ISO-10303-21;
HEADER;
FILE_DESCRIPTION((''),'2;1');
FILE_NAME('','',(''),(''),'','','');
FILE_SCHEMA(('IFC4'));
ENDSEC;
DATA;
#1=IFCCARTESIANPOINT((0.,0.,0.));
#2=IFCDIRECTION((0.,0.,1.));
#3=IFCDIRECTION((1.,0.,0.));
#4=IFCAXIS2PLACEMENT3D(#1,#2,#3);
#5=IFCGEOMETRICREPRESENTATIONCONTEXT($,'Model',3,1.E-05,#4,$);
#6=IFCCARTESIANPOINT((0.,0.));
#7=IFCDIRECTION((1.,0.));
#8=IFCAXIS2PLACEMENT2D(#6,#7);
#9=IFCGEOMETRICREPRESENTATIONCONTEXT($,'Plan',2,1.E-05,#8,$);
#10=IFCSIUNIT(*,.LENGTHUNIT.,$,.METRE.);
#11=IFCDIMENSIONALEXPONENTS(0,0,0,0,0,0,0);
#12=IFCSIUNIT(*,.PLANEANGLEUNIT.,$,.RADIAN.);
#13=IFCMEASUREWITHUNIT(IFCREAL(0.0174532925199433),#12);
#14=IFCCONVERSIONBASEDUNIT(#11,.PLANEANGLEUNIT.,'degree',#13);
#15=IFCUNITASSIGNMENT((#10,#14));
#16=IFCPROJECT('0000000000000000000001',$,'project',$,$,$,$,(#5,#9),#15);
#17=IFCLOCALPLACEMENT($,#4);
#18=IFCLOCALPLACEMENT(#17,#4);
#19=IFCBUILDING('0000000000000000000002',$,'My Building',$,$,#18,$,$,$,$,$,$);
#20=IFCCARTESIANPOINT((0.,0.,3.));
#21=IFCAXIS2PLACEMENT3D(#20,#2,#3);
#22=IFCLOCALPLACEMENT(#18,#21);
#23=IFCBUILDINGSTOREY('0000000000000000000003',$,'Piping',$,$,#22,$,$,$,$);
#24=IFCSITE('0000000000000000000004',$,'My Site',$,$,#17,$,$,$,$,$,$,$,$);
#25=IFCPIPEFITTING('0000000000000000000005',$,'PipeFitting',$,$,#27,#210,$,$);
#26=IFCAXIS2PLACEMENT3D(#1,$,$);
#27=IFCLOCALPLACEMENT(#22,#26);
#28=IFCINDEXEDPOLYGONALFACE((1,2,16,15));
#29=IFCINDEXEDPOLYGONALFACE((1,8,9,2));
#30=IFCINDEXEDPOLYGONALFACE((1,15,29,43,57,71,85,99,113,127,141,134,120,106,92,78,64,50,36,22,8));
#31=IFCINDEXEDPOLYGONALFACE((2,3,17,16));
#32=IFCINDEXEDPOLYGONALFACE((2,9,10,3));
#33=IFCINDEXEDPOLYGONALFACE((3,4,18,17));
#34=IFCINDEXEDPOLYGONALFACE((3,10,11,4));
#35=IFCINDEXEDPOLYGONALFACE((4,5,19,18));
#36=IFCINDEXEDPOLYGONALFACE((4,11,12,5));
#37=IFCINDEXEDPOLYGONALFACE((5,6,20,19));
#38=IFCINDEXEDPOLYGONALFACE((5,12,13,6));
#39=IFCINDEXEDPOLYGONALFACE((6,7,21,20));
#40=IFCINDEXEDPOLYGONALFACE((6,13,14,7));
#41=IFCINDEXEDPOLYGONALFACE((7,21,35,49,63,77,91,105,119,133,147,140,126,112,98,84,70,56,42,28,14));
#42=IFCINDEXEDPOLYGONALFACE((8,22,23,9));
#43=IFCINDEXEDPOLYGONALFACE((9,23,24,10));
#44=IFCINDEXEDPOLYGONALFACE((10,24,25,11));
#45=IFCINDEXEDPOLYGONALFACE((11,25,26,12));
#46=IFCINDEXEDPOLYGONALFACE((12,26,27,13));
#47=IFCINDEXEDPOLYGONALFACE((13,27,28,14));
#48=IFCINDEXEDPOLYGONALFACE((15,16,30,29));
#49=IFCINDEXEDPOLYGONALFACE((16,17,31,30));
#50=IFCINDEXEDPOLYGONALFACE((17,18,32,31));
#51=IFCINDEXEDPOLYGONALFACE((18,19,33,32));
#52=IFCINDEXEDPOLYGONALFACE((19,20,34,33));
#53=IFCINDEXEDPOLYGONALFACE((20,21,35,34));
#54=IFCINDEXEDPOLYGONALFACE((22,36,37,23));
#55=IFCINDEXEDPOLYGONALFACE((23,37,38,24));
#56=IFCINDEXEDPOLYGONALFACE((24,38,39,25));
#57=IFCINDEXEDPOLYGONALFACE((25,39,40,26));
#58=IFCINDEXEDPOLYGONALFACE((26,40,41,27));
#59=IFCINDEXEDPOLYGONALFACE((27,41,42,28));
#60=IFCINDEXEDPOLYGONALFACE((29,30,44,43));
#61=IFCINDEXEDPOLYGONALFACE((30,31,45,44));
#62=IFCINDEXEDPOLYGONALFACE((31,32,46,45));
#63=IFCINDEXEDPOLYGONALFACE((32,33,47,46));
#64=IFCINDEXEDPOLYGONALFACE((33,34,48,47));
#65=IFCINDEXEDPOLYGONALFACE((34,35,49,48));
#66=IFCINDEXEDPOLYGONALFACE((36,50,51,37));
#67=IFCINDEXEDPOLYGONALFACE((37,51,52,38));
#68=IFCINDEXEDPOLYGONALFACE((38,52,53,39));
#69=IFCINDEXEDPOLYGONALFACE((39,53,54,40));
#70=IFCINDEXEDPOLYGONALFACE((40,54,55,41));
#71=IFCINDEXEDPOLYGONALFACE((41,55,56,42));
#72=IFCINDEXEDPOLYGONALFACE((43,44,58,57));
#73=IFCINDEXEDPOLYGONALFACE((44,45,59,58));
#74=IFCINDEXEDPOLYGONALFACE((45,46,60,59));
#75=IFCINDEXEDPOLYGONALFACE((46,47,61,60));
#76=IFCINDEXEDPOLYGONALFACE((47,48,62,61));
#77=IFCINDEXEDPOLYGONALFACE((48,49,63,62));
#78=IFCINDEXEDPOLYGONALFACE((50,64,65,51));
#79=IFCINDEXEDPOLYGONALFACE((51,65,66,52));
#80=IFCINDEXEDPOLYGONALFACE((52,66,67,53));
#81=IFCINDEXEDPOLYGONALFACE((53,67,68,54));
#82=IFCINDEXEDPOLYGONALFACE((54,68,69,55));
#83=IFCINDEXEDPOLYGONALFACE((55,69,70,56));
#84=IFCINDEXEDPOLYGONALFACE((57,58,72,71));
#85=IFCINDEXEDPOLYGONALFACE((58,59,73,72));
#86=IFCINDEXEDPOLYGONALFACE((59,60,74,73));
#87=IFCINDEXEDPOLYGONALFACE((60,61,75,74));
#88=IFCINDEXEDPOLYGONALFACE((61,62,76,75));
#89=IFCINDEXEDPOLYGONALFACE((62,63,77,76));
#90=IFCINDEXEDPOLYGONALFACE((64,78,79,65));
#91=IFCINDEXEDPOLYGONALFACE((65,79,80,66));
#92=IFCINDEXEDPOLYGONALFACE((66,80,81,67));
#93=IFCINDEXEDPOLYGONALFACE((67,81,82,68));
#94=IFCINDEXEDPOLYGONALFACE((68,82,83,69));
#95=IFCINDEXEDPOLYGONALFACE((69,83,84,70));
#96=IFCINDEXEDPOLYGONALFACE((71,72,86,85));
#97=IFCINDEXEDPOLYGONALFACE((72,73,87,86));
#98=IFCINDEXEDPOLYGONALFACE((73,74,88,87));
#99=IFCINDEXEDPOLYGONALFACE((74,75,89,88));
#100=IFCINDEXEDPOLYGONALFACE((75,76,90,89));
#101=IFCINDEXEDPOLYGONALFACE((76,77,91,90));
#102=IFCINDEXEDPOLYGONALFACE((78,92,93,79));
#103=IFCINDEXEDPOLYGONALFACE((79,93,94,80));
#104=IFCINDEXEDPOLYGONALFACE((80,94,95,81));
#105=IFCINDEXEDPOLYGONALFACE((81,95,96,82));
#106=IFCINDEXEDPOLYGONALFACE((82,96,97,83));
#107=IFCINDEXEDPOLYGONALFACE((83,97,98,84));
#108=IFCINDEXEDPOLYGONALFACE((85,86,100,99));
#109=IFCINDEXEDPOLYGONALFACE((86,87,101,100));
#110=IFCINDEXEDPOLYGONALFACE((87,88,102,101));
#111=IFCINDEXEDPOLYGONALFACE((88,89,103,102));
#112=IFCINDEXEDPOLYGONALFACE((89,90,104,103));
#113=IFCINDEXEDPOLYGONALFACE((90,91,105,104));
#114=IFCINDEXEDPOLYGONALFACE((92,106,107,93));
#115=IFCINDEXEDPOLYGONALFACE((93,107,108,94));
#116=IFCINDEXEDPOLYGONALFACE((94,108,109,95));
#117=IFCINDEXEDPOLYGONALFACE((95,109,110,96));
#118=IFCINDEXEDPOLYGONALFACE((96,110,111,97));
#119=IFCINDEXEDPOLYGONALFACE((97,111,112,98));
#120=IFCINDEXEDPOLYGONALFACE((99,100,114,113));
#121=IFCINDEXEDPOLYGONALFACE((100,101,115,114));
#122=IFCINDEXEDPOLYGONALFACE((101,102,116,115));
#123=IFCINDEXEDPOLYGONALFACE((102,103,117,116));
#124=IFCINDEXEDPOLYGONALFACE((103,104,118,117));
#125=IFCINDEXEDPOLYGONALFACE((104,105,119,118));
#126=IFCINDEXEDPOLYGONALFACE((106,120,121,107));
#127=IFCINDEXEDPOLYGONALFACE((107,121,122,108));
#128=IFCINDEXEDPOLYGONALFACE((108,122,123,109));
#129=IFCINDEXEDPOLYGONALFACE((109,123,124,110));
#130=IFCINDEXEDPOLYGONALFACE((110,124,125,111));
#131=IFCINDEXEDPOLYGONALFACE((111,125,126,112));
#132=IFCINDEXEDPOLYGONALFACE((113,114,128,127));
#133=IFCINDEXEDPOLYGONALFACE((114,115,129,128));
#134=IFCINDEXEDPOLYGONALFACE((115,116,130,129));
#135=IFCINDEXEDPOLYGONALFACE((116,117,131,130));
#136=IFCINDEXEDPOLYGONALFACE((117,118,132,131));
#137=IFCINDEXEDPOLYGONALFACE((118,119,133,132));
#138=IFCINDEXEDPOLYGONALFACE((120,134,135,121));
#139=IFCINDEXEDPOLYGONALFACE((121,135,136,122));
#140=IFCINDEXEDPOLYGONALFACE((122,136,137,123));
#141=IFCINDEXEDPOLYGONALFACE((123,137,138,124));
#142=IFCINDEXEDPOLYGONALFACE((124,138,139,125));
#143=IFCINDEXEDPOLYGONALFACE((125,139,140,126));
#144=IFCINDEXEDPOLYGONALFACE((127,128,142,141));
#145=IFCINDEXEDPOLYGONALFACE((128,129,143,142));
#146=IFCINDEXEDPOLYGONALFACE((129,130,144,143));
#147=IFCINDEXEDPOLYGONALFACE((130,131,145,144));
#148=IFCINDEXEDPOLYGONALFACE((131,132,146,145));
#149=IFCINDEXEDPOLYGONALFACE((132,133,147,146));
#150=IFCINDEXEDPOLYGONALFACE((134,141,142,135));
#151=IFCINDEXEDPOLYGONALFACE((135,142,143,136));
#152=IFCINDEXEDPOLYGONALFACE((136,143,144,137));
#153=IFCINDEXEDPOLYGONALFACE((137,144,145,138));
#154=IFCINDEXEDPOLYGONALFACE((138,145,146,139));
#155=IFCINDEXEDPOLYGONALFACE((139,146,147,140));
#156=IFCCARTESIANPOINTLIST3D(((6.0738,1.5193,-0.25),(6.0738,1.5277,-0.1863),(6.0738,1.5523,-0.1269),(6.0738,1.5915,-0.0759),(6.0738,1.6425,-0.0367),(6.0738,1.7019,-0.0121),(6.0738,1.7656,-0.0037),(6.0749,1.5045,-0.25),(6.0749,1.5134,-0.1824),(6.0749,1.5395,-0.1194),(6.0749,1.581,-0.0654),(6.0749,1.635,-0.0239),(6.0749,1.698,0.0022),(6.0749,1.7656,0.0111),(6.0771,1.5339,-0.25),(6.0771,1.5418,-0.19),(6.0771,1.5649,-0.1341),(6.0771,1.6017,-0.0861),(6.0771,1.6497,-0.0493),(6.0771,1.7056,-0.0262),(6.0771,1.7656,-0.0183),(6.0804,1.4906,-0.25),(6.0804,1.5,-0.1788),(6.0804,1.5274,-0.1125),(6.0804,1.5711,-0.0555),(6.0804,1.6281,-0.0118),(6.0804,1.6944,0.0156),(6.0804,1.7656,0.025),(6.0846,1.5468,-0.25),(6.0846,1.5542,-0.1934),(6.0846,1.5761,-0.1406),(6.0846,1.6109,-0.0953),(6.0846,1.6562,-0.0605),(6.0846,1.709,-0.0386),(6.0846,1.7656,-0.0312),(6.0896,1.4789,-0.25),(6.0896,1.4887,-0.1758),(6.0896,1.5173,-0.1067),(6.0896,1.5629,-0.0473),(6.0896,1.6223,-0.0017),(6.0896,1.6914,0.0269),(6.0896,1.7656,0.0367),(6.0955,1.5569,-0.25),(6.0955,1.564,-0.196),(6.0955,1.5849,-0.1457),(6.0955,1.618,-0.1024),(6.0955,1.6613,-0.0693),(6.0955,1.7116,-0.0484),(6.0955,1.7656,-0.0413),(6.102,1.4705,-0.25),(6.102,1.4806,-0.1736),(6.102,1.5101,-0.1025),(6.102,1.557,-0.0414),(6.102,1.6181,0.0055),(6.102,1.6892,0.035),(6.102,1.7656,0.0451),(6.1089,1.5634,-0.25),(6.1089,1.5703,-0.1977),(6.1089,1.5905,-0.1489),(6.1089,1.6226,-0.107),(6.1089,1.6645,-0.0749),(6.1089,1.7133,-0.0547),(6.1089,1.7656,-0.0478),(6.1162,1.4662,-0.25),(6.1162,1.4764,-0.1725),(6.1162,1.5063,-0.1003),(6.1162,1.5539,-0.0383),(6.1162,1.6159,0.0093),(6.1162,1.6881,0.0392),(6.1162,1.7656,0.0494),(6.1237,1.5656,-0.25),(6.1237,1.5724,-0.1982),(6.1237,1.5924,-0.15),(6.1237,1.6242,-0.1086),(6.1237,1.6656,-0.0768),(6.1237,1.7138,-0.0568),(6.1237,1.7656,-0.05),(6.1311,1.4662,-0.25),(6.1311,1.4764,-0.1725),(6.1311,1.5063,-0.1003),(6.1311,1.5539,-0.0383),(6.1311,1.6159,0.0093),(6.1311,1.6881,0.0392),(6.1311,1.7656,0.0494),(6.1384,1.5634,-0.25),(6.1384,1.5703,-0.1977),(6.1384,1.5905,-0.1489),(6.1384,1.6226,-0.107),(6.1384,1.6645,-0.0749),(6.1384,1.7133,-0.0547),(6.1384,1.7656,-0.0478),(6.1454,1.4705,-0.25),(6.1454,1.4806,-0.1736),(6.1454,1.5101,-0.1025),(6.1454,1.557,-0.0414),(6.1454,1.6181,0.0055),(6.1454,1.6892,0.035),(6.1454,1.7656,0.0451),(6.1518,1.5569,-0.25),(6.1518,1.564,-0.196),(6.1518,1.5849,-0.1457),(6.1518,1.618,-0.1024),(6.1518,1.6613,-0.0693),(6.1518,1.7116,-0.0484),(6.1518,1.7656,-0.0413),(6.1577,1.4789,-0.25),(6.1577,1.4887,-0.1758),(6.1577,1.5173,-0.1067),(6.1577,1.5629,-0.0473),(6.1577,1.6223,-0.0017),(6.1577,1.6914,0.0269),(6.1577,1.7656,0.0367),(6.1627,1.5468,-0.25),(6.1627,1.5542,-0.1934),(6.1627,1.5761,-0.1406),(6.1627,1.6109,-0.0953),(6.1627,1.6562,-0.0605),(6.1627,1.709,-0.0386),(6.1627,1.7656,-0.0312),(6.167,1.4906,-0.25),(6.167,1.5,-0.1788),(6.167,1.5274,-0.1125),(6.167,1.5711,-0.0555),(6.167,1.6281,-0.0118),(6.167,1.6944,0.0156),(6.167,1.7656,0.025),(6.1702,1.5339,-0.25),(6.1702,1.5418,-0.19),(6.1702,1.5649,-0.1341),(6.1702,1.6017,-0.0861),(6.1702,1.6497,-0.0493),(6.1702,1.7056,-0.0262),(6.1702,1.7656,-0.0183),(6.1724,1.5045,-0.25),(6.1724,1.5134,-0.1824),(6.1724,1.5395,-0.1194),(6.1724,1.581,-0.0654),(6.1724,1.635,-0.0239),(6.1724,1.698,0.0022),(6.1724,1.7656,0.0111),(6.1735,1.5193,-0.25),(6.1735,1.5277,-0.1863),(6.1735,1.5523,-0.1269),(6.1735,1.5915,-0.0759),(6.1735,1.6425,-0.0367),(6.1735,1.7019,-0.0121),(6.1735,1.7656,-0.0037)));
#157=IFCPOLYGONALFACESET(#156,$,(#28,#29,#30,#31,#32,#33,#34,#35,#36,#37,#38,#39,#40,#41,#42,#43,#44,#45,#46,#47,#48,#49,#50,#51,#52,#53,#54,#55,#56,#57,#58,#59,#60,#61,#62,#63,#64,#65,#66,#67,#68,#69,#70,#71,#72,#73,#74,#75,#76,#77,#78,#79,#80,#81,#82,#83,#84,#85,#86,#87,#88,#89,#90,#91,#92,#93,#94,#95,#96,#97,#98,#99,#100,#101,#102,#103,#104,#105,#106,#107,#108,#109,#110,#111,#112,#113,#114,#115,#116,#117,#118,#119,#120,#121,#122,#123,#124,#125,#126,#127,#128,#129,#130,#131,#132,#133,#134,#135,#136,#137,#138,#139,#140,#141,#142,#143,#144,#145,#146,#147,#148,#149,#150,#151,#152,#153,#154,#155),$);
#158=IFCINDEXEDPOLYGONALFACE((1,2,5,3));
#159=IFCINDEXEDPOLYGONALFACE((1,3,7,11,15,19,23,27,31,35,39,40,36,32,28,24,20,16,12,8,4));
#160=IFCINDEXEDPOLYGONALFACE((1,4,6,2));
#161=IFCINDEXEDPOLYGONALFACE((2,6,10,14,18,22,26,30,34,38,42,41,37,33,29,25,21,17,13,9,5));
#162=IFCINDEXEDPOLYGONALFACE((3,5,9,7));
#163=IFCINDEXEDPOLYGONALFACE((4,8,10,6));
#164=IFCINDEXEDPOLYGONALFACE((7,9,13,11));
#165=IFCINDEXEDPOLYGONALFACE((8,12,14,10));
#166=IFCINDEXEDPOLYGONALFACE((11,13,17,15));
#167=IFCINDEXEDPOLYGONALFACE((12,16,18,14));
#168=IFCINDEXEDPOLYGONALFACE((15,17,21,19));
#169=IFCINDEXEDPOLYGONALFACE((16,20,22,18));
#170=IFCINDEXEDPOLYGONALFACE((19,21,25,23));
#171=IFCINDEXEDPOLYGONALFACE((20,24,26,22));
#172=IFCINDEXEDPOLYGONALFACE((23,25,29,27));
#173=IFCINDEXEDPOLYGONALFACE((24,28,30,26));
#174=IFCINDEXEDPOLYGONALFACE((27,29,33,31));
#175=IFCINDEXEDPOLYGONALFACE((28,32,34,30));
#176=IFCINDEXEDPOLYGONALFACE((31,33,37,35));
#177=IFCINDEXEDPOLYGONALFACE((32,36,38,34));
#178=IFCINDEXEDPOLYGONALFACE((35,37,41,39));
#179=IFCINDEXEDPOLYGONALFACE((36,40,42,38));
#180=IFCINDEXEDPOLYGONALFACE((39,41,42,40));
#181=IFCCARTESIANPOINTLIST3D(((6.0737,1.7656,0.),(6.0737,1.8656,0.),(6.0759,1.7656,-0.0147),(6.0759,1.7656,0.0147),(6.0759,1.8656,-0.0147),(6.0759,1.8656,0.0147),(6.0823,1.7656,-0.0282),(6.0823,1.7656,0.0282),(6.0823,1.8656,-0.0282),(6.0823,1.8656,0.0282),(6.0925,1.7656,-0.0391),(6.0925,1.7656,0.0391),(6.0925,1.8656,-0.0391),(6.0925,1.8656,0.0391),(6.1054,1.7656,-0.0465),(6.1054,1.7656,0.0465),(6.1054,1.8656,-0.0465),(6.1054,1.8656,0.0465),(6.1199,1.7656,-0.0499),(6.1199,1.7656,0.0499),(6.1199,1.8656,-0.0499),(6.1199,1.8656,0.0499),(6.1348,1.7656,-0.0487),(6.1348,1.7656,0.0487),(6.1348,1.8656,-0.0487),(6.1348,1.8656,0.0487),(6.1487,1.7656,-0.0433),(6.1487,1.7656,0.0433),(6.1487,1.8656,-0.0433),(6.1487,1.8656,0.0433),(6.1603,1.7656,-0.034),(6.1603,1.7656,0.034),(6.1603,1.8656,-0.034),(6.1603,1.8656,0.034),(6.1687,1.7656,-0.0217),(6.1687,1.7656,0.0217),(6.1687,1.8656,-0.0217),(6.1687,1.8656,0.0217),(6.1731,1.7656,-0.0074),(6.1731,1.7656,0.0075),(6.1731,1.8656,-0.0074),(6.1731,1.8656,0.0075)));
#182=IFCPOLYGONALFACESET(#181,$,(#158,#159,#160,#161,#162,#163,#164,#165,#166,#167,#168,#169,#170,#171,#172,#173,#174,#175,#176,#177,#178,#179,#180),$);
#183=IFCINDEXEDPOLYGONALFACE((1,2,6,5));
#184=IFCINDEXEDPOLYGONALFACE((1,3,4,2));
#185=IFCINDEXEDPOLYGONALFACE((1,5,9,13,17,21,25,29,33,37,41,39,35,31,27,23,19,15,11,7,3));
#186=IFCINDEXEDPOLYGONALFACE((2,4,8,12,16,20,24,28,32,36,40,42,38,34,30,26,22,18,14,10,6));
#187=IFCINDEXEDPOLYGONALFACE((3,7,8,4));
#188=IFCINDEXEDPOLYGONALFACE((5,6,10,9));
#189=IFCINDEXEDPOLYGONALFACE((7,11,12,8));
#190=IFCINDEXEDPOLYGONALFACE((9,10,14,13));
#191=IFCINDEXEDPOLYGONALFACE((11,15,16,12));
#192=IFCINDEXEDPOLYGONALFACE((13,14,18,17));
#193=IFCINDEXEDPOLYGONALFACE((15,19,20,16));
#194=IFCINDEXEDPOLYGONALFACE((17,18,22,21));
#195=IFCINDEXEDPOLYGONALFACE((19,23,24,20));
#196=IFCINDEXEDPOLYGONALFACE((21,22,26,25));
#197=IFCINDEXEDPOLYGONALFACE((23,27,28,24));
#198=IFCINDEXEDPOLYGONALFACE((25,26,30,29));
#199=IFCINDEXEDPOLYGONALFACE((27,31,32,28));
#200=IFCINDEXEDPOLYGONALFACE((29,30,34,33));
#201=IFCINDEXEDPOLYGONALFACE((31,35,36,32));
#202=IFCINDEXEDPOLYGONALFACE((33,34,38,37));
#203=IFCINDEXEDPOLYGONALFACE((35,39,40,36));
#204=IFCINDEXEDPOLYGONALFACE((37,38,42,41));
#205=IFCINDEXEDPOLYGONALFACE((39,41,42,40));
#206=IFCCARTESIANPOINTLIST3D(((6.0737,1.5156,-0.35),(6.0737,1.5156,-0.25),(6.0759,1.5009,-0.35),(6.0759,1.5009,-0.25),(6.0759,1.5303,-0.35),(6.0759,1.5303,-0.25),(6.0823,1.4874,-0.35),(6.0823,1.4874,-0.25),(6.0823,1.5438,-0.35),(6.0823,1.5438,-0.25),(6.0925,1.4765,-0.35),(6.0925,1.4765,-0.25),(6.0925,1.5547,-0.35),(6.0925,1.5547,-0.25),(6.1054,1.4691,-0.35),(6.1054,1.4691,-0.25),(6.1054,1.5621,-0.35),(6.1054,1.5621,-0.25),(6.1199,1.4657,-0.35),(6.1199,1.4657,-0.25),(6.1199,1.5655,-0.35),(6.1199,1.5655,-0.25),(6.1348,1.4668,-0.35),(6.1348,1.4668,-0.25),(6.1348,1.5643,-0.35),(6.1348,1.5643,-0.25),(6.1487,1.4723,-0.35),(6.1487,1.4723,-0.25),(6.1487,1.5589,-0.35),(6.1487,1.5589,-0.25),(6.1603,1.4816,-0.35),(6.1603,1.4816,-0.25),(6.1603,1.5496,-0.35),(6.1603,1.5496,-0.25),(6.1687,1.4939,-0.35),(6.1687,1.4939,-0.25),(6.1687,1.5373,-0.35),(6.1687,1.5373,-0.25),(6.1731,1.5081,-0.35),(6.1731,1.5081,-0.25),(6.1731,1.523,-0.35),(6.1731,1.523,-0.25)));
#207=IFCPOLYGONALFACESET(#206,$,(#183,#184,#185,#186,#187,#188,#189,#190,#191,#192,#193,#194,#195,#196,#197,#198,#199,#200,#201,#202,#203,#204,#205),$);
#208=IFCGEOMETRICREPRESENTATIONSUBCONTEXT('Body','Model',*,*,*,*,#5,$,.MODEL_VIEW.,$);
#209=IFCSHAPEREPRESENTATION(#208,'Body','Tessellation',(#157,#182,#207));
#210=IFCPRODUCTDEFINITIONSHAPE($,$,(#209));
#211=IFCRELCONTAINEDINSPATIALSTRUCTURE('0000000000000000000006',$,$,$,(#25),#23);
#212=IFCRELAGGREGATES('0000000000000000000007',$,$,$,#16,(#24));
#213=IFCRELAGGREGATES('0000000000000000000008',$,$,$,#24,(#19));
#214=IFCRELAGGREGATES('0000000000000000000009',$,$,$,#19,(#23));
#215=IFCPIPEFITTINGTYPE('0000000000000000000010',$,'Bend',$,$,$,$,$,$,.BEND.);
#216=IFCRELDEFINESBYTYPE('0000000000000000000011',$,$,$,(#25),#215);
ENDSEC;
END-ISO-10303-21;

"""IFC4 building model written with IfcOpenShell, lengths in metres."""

from ifc_helpers import new_model, entity, si_unit, converted_unit, frame, origin_with_axes, origin_2d_with_axis, place, context, subcontext, project, spatial, circle, extrude, source, transform, mapped, type_object, type_shapes, element, save


model = new_model("IFC4")

# Units and contexts
model_context = context("Model", 3, precision=1e-05, world=origin_with_axes())
plan_context = context("Plan", 2, precision=1e-05, world=origin_2d_with_axis())
body_context = subcontext(model_context, "Body", "Model", "MODEL_VIEW")
ifc_project = project(units=[si_unit("LENGTHUNIT", "METRE"), converted_unit("PLANEANGLEUNIT", "degree", entity("IfcReal", 0.0174532925199433), si_unit("PLANEANGLEUNIT", "RADIAN"), dimensions=[0, 0, 0, 0, 0, 0, 0])], contexts=[model_context, plan_context])

# Site, building, storey
site_placement = place(None, origin_with_axes())
site = spatial("IfcSite", under=ifc_project, at=site_placement, Name="My Site")
building_placement = place(site_placement, origin_with_axes())
building = spatial("IfcBuilding", under=site, at=building_placement, Name="My Building")
storey_placement = place(building_placement, frame((0.0, 0.0, 3.0), z_axis=(0.0, 0.0, 1.0), x_axis=(1.0, 0.0, 0.0)))
storey = spatial("IfcBuildingStorey", under=building, at=storey_placement, Name="Piping")

# Shared definitions
pipe_fitting_type = type_object("IfcPipeFittingType", Name="Bend", PredefinedType="BEND")
shared_shape = source(origin_with_axes(), body_context, "Body", "SolidModel", [
    entity("IfcSweptDiskSolid", entity("IfcIndexedPolyCurve", entity("IfcCartesianPointList3D", [[0.0, 0.0, -0.1], [0.0, -0.0732, -0.2768], [0.0, -0.25, -0.35]]), [entity("IfcArcIndex", [1, 2, 3])]), 0.05),
    extrude(circle(Radius=0.05), origin_with_axes(), (0.0, 0.0, -1.0), 0.1),
    extrude(circle(Radius=0.05), frame((0.0, -0.25, -0.35), z_axis=(0.0, -1.0, 0.0), x_axis=(1.0, 0.0, 0.0)), (0.0, 0.0, 1.0), 0.1),
])
type_shapes(pipe_fitting_type, [shared_shape])

# Pipe fitting
for number, where, z_axis, x_axis, name in (
    (1, (6.1237, 1.8656, 0.0), (0.0, 1.0, 0.0), (-1.0, 0.0, 0.0), "PipeFitting"),
):
    element("IfcPipeFitting", number, at=place(storey_placement, frame(where, z_axis=z_axis, x_axis=x_axis)), inside=storey, type_object=pipe_fitting_type, Name=name, context=body_context, shape_type="MappedRepresentation", body=[
        mapped(shared_shape, transform((0.0, 0.0, 0.0), x_axis=(1.0, 0.0, 0.0), y_axis=(0.0, 1.0, 0.0), z_axis=(0.0, 0.0, 1.0), scale=1.0)),
    ])

save(model, "model.ifc")
